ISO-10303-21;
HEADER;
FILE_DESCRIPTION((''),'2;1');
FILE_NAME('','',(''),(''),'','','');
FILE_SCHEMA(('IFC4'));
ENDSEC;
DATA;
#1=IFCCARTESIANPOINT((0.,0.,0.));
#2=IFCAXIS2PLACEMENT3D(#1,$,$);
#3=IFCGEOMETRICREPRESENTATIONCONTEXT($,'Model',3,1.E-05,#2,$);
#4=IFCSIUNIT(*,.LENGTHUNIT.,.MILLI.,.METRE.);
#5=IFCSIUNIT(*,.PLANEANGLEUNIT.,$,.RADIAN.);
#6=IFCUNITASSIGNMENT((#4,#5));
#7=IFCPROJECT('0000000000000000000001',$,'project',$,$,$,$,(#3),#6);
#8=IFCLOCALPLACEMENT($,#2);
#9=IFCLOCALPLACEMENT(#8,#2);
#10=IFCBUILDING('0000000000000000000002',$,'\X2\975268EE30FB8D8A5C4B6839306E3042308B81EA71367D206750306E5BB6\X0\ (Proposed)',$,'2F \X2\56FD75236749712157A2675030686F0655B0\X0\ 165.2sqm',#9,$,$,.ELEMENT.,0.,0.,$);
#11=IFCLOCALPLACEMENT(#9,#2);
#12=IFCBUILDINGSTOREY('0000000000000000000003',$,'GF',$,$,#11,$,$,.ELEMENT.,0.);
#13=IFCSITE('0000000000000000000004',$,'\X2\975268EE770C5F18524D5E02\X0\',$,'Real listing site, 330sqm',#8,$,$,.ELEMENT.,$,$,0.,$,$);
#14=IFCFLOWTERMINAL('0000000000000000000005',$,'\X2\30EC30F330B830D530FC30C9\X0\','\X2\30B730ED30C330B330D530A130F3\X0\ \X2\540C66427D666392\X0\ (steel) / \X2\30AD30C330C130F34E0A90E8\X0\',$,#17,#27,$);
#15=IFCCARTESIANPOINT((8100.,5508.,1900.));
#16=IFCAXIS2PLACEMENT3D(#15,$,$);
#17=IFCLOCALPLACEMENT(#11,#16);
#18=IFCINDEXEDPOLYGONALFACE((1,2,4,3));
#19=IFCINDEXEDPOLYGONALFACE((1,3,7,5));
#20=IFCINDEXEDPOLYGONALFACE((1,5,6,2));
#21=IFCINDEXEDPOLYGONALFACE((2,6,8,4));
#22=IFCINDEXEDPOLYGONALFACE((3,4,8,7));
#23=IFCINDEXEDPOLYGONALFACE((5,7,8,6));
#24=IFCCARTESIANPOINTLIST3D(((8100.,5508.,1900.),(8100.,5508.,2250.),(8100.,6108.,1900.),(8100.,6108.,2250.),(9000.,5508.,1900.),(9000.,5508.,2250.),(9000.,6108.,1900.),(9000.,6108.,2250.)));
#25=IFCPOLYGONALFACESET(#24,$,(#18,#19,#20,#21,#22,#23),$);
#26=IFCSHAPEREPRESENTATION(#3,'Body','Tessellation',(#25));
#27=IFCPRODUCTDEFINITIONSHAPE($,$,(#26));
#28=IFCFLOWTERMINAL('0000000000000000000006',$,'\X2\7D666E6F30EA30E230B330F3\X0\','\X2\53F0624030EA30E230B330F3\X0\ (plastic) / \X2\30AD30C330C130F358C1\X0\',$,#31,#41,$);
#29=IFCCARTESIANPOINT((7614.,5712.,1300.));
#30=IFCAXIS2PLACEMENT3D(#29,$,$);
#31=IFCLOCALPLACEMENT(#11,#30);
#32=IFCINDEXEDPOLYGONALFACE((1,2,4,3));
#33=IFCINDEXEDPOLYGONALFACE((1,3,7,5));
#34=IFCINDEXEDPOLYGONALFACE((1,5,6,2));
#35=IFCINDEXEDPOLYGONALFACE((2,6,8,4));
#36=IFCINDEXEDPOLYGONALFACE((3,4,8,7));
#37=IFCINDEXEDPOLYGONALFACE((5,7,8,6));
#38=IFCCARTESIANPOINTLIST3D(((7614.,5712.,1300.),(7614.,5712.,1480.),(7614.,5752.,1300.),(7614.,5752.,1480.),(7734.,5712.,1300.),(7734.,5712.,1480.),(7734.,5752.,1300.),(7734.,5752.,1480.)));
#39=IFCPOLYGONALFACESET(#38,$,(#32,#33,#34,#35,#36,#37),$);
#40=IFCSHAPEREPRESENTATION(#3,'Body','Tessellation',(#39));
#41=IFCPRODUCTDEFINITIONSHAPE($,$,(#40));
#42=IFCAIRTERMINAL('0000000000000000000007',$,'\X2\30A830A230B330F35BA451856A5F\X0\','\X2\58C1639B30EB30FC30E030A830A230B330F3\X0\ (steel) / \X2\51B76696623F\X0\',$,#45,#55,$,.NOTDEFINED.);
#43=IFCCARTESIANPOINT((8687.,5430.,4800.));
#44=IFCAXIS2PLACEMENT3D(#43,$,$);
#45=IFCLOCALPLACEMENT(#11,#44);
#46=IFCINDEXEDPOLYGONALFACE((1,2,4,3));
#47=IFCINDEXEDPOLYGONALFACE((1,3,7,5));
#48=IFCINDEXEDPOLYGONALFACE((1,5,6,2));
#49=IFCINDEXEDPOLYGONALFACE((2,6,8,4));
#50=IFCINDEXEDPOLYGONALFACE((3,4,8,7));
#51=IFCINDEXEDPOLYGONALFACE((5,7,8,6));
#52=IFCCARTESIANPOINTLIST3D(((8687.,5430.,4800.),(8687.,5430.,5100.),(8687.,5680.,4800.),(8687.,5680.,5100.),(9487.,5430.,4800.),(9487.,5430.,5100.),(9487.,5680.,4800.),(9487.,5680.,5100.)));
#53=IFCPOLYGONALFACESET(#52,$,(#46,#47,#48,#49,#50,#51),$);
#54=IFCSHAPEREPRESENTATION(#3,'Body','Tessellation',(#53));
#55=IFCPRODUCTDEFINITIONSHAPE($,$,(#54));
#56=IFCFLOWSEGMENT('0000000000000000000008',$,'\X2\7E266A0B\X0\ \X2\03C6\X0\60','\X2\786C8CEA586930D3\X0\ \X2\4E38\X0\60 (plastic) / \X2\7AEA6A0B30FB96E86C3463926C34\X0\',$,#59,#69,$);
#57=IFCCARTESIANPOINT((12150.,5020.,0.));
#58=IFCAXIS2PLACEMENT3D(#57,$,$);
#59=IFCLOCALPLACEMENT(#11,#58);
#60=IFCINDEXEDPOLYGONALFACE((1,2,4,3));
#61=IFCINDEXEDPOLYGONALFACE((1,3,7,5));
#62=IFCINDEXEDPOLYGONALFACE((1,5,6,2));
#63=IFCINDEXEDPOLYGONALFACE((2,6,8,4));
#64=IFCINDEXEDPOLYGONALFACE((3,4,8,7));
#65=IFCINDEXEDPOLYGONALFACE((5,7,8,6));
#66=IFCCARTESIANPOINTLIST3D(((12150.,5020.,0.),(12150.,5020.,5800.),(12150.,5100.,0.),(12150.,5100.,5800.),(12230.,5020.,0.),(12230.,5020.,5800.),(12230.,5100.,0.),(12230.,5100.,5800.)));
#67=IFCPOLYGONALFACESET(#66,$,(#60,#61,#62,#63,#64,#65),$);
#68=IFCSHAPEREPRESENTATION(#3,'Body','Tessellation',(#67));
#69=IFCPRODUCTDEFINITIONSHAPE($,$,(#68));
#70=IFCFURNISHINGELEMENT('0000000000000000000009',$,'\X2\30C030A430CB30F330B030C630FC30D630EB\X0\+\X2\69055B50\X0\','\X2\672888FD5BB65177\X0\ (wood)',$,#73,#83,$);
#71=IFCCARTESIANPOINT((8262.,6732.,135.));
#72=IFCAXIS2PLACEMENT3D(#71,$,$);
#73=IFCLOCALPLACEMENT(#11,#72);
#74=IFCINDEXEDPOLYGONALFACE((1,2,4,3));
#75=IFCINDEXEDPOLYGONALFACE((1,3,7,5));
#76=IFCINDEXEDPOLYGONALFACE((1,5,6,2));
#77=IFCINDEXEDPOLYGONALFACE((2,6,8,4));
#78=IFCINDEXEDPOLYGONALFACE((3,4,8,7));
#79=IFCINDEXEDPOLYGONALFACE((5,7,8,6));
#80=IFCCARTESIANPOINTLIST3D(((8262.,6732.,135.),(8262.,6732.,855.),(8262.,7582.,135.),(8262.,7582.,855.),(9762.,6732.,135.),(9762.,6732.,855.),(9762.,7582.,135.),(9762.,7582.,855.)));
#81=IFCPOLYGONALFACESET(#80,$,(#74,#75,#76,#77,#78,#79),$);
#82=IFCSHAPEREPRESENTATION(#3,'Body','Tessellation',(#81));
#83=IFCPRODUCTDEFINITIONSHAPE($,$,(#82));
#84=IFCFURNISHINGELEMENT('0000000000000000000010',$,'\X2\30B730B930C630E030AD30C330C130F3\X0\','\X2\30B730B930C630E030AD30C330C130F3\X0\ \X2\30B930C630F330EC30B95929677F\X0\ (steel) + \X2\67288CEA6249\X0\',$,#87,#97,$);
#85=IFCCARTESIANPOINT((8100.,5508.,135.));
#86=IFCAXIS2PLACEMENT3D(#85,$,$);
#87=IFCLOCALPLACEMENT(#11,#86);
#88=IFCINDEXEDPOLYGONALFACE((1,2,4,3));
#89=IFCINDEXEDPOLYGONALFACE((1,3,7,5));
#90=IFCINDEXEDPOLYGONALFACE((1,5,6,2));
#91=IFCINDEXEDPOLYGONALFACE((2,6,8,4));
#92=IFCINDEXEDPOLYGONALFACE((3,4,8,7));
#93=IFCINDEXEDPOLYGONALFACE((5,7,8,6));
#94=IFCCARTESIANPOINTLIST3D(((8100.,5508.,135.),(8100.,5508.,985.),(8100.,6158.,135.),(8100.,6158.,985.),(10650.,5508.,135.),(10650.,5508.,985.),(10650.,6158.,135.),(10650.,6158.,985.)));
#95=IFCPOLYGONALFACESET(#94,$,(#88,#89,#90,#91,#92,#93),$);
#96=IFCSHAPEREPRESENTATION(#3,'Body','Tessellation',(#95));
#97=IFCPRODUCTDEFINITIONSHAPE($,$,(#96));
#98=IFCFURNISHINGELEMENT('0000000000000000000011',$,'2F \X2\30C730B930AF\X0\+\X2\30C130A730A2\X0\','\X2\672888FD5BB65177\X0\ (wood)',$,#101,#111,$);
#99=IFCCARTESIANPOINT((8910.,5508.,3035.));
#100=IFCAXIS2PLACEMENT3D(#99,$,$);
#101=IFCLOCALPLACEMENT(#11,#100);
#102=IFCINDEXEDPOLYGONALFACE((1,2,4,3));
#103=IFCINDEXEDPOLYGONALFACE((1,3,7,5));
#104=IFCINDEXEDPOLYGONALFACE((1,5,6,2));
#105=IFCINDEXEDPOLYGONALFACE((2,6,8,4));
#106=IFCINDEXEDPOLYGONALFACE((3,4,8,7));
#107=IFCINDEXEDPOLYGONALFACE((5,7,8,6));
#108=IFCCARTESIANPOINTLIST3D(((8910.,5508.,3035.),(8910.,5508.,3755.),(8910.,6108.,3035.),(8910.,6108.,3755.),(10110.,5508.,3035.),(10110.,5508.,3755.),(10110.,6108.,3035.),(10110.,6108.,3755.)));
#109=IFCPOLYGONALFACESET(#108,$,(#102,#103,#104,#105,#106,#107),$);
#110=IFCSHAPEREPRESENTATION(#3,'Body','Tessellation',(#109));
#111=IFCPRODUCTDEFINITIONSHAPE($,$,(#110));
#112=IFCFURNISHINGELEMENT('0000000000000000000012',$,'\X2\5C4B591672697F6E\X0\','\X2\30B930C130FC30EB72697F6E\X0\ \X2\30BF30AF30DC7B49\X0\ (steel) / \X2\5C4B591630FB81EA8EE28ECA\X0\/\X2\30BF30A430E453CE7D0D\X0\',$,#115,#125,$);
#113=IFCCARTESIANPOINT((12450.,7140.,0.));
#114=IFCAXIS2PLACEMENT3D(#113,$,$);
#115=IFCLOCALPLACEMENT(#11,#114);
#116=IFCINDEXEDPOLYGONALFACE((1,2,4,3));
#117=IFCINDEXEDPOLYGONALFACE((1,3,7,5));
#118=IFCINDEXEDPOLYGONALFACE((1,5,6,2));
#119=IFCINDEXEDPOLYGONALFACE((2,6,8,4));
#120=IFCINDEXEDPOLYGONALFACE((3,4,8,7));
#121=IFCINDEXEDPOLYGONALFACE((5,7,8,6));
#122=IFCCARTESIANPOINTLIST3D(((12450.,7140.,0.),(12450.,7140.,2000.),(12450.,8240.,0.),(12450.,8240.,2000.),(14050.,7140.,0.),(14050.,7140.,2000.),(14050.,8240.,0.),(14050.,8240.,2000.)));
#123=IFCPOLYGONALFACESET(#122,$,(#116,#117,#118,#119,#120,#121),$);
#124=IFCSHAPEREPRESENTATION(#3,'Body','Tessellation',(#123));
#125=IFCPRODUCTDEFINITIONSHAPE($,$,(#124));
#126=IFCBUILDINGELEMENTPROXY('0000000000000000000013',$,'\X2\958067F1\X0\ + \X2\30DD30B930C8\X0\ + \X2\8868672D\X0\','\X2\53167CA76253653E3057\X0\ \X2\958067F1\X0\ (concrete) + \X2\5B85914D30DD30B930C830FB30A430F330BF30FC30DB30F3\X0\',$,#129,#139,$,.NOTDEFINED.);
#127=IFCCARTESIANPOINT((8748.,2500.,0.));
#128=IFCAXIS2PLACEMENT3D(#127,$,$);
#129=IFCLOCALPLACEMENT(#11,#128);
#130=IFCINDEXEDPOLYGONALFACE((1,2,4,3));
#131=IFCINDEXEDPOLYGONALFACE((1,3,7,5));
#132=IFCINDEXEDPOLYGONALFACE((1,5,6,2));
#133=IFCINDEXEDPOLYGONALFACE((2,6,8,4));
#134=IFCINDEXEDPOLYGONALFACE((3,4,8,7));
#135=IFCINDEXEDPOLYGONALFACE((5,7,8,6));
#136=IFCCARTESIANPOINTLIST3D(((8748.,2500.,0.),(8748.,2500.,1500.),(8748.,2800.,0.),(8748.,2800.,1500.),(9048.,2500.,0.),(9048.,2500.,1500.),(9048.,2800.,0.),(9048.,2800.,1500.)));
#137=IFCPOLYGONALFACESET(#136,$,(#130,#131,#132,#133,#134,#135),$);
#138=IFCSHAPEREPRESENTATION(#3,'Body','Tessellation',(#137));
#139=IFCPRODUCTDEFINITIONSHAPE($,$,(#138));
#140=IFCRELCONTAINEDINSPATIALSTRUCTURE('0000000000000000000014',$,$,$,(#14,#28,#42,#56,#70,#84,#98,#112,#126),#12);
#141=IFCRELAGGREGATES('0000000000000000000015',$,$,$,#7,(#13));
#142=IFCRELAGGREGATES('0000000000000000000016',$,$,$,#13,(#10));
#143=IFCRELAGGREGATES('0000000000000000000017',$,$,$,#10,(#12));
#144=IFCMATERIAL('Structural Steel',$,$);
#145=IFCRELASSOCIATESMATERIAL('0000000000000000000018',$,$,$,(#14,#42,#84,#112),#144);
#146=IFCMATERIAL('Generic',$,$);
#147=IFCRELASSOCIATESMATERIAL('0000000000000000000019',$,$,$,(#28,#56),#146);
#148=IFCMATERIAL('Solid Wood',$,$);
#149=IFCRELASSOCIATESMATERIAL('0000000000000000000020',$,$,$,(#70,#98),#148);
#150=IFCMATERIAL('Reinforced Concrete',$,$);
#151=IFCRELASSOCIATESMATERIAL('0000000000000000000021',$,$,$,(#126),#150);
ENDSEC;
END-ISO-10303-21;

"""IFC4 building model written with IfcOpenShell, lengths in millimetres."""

from ifc_helpers import new_model, si_unit, frame, frame_2d, origin, place, context, project, spatial, rectangle, extrude, material, element, save


model = new_model("IFC4")

# Units and contexts
model_context = context("Model", 3, precision=1e-05, world=origin())
ifc_project = project(units=[si_unit("LENGTHUNIT", "METRE", prefix="MILLI"), si_unit("PLANEANGLEUNIT", "RADIAN")], contexts=[model_context])

# Site, building, storey
site_placement = place(None, origin())
site = spatial("IfcSite", under=ifc_project, at=site_placement, Name="青森県弘前市", ObjectType="Real listing site, 330sqm", CompositionType="ELEMENT", RefElevation=0.0)
building_placement = place(site_placement, origin())
building = spatial("IfcBuilding", under=site, at=building_placement, Name="青森・越屋根のある自然素材の家 (Proposed)", ObjectType="2F 国産杉無垢材と漆喰 165.2sqm", CompositionType="ELEMENT", ElevationOfRefHeight=0.0, ElevationOfTerrain=0.0)
storey_placement = place(building_placement, origin())
storey = spatial("IfcBuildingStorey", under=building, at=storey_placement, Name="GF", CompositionType="ELEMENT", Elevation=0.0)

# Shared definitions
ifc_material_1 = material(Name="Solid Wood")

# Shared definitions
ifc_material_2 = material(Name="Reinforced Concrete")

# Shared definitions
ifc_material_3 = material(Name="Structural Steel")

# Flow terminals
flow_terminal_1_placement = place(storey_placement, frame((8100.0, 5508.0, 1900.0)))
element("IfcFlowTerminal", 1, at=flow_terminal_1_placement, inside=storey, material=ifc_material_3, Name="レンジフード", Description="シロッコファン 同時給排 (steel) / キッチン上部", context=model_context, shape_type="SweptSolid", body=[
    extrude(rectangle(XDim=900.0, YDim=600.0, at=frame_2d((450.0, 300.0))), frame((8100.0, 5508.0, 1900.0)), (0.0, 0.0, 1.0), 350.0),
])
ifc_material_4 = material(Name="Generic")
flow_terminal_2_placement = place(storey_placement, frame((7614.0, 5712.0, 1300.0)))
element("IfcFlowTerminal", 2, at=flow_terminal_2_placement, inside=storey, material=ifc_material_4, Name="給湯リモコン", Description="台所リモコン (plastic) / キッチン壁", context=model_context, shape_type="SweptSolid", body=[
    extrude(rectangle(XDim=120.0, YDim=40.0, at=frame_2d((60.0, 20.0))), frame((7614.0, 5712.0, 1300.0)), (0.0, 0.0, 1.0), 180.0),
])

# Air terminal
air_terminal_placement = place(storey_placement, frame((8687.0, 5430.0, 4800.0)))
element("IfcAirTerminal", 3, at=air_terminal_placement, inside=storey, material=ifc_material_3, Name="エアコン室内機", Description="壁掛ルームエアコン (steel) / 冷暖房", PredefinedType="NOTDEFINED", context=model_context, shape_type="SweptSolid", body=[
    extrude(rectangle(XDim=800.0, YDim=250.0, at=frame_2d((400.0, 125.0))), frame((8687.0, 5430.0, 4800.0)), (0.0, 0.0, 1.0), 300.0),
])

# Flow segment
flow_segment_placement = place(storey_placement, frame((12150.0, 5020.0, 0.0)))
element("IfcFlowSegment", 4, at=flow_segment_placement, inside=storey, material=ifc_material_4, Name="縦樋 φ60", Description="硬質塩ビ 丸60 (plastic) / 竪樋・雨水排水", context=model_context, shape_type="SweptSolid", body=[
    extrude(rectangle(XDim=80.0, YDim=80.0, at=frame_2d((40.0, 40.0))), frame((12150.0, 5020.0, 0.0)), (0.0, 0.0, 1.0), 5800.0),
])

# Furnishing elements
furnishing_1_placement = place(storey_placement, frame((8262.0, 6732.0, 135.0)))
element("IfcFurnishingElement", 5, at=furnishing_1_placement, inside=storey, material=ifc_material_1, Name="ダイニングテーブル+椅子", Description="木製家具 (wood)", context=model_context, shape_type="SweptSolid", body=[
    extrude(rectangle(XDim=1500.0, YDim=850.0, at=frame_2d((750.0, 425.0))), frame((8262.0, 6732.0, 135.0)), (0.0, 0.0, 1.0), 720.0),
])
furnishing_2_placement = place(storey_placement, frame((8100.0, 5508.0, 135.0)))
element("IfcFurnishingElement", 6, at=furnishing_2_placement, inside=storey, material=ifc_material_3, Name="システムキッチン", Description="システムキッチン ステンレス天板 (steel) + 木質扉", context=model_context, shape_type="SweptSolid", body=[
    extrude(rectangle(XDim=2550.0, YDim=650.0, at=frame_2d((1275.0, 325.0))), frame((8100.0, 5508.0, 135.0)), (0.0, 0.0, 1.0), 850.0),
])
furnishing_3_placement = place(storey_placement, frame((8910.0, 5508.0, 3035.0)))
element("IfcFurnishingElement", 7, at=furnishing_3_placement, inside=storey, material=ifc_material_1, Name="2F デスク+チェア", Description="木製家具 (wood)", context=model_context, shape_type="SweptSolid", body=[
    extrude(rectangle(XDim=1200.0, YDim=600.0, at=frame_2d((600.0, 300.0))), frame((8910.0, 5508.0, 3035.0)), (0.0, 0.0, 1.0), 720.0),
])
furnishing_4_placement = place(storey_placement, frame((12450.0, 7140.0, 0.0)))
element("IfcFurnishingElement", 8, at=furnishing_4_placement, inside=storey, material=ifc_material_3, Name="屋外物置", Description="スチール物置 タクボ等 (steel) / 屋外・自転車/タイヤ収納", context=model_context, shape_type="SweptSolid", body=[
    extrude(rectangle(XDim=1600.0, YDim=1100.0, at=frame_2d((800.0, 550.0))), frame((12450.0, 7140.0, 0.0)), (0.0, 0.0, 1.0), 2000.0),
])

# Building element proxy
proxy_placement = place(storey_placement, frame((8748.0, 2500.0, 0.0)))
element("IfcBuildingElementProxy", 9, at=proxy_placement, inside=storey, material=ifc_material_2, Name="門柱 + ポスト + 表札", Description="化粧打放し 門柱 (concrete) + 宅配ポスト・インターホン", PredefinedType="NOTDEFINED", context=model_context, shape_type="SweptSolid", body=[
    extrude(rectangle(XDim=300.0, YDim=300.0, at=frame_2d((150.0, 150.0))), frame((8748.0, 2500.0, 0.0)), (0.0, 0.0, 1.0), 1500.0),
])

save(model, "model.ifc")
